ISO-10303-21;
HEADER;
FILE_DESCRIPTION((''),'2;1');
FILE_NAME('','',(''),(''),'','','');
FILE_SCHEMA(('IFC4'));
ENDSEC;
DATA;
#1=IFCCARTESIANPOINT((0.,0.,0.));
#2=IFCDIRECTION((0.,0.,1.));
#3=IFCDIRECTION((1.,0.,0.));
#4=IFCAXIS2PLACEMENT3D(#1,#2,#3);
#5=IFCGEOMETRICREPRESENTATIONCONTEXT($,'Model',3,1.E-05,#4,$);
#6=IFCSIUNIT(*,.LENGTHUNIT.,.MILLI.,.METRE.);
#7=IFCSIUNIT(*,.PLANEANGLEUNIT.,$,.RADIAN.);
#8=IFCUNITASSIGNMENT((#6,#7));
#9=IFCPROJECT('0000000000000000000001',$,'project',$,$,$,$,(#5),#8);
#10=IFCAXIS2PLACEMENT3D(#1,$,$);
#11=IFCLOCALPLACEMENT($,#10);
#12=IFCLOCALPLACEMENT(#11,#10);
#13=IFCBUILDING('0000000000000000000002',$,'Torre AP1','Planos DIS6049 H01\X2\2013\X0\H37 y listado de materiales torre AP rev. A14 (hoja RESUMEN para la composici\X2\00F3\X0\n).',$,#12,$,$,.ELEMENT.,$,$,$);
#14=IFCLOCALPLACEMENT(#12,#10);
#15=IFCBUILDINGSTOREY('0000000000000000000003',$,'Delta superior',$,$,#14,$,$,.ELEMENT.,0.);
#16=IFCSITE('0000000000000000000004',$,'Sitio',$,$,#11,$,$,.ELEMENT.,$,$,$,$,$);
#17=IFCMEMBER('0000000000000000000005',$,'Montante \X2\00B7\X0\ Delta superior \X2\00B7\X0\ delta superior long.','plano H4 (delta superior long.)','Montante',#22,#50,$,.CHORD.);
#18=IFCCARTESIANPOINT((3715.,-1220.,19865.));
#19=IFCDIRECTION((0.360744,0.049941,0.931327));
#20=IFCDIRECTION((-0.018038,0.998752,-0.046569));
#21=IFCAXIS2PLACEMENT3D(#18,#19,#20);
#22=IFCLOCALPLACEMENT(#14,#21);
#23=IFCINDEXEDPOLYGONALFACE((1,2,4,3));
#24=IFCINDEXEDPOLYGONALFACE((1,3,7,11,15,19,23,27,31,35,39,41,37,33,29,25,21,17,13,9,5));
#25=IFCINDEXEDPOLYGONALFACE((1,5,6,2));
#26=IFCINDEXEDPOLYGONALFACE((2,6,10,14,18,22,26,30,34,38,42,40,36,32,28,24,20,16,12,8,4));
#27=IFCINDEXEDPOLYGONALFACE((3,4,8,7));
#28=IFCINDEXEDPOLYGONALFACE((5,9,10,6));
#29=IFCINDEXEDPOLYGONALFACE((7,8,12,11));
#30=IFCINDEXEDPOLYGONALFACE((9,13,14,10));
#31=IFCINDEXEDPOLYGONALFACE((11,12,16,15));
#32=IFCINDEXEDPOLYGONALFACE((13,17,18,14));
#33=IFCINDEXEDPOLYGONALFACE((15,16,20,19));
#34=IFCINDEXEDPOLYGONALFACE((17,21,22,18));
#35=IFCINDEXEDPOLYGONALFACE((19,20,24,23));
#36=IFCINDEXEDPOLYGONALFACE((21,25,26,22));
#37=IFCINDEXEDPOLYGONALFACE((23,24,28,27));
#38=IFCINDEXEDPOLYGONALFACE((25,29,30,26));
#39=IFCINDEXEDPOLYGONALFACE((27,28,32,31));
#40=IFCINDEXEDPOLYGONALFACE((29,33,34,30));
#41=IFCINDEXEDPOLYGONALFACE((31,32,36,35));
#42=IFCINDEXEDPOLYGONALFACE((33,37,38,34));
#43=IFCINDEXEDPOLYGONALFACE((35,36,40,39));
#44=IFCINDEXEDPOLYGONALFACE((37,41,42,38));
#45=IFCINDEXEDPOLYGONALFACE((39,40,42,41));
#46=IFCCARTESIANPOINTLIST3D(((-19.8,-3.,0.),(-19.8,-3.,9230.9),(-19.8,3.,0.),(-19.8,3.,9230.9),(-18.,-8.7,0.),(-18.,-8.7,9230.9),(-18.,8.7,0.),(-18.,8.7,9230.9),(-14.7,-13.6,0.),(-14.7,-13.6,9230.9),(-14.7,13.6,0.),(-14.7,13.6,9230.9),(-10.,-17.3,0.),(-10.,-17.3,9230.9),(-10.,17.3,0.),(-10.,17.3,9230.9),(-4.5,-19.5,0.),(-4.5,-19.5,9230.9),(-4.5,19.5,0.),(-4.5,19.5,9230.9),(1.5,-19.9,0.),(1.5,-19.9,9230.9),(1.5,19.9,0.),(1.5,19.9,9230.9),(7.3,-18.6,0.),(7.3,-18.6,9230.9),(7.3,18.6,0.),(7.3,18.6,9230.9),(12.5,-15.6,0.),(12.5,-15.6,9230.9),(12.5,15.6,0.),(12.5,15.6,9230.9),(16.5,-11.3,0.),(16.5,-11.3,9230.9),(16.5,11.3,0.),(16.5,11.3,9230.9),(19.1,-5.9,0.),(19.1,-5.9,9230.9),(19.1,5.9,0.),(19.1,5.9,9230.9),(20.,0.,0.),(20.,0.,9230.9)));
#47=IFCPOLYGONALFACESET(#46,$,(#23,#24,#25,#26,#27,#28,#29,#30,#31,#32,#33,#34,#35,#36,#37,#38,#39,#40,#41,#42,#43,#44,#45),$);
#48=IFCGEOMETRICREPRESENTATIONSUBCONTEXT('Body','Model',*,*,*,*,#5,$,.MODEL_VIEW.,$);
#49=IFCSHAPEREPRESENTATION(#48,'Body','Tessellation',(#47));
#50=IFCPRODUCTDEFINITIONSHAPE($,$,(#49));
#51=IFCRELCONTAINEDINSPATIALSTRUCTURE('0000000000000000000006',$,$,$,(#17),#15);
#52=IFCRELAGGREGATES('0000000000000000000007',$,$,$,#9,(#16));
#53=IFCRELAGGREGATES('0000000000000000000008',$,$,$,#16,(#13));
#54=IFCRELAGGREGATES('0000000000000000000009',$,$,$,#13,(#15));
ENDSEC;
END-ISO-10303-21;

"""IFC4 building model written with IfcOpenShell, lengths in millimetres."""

from ifc_helpers import new_model, si_unit, frame, origin, origin_with_axes, place, context, subcontext, project, spatial, circle, extrude, element, save


model = new_model("IFC4")

# Units and contexts
model_context = context("Model", 3, precision=1e-05, world=origin_with_axes())
body_context = subcontext(model_context, "Body", "Model", "MODEL_VIEW")
ifc_project = project(units=[si_unit("LENGTHUNIT", "METRE", prefix="MILLI"), si_unit("PLANEANGLEUNIT", "RADIAN")], contexts=[model_context])

# Site, building, storey
site_placement = place(None, origin())
site = spatial("IfcSite", under=ifc_project, at=site_placement, Name="Sitio", CompositionType="ELEMENT")
building_placement = place(site_placement, origin())
building = spatial("IfcBuilding", under=site, at=building_placement, Name="Torre AP1", Description="Planos DIS6049 H01–H37 y listado de materiales torre AP rev. A14 (hoja RESUMEN para la composición).", CompositionType="ELEMENT")
storey_placement = place(building_placement, origin())
storey = spatial("IfcBuildingStorey", under=building, at=storey_placement, Name="Delta superior", CompositionType="ELEMENT", Elevation=0.0)

# Member
for number, where, z_axis, x_axis, name in (
    (1, (3715.0, -1220.0, 19865.0), (0.360744, 0.049941, 0.931327), (-0.018038, 0.998752, -0.046569), "Montante · Delta superior · delta superior long."),
):
    element("IfcMember", number, at=place(storey_placement, frame(where, z_axis=z_axis, x_axis=x_axis)), inside=storey, Name=name, Description="plano H4 (delta superior long.)", ObjectType="Montante", PredefinedType="CHORD", context=body_context, shape_type="SweptSolid", body=[
        extrude(circle(Radius=20.0), None, (0.0, 0.0, 1.0), 9230.9),
    ])

save(model, "model.ifc")
